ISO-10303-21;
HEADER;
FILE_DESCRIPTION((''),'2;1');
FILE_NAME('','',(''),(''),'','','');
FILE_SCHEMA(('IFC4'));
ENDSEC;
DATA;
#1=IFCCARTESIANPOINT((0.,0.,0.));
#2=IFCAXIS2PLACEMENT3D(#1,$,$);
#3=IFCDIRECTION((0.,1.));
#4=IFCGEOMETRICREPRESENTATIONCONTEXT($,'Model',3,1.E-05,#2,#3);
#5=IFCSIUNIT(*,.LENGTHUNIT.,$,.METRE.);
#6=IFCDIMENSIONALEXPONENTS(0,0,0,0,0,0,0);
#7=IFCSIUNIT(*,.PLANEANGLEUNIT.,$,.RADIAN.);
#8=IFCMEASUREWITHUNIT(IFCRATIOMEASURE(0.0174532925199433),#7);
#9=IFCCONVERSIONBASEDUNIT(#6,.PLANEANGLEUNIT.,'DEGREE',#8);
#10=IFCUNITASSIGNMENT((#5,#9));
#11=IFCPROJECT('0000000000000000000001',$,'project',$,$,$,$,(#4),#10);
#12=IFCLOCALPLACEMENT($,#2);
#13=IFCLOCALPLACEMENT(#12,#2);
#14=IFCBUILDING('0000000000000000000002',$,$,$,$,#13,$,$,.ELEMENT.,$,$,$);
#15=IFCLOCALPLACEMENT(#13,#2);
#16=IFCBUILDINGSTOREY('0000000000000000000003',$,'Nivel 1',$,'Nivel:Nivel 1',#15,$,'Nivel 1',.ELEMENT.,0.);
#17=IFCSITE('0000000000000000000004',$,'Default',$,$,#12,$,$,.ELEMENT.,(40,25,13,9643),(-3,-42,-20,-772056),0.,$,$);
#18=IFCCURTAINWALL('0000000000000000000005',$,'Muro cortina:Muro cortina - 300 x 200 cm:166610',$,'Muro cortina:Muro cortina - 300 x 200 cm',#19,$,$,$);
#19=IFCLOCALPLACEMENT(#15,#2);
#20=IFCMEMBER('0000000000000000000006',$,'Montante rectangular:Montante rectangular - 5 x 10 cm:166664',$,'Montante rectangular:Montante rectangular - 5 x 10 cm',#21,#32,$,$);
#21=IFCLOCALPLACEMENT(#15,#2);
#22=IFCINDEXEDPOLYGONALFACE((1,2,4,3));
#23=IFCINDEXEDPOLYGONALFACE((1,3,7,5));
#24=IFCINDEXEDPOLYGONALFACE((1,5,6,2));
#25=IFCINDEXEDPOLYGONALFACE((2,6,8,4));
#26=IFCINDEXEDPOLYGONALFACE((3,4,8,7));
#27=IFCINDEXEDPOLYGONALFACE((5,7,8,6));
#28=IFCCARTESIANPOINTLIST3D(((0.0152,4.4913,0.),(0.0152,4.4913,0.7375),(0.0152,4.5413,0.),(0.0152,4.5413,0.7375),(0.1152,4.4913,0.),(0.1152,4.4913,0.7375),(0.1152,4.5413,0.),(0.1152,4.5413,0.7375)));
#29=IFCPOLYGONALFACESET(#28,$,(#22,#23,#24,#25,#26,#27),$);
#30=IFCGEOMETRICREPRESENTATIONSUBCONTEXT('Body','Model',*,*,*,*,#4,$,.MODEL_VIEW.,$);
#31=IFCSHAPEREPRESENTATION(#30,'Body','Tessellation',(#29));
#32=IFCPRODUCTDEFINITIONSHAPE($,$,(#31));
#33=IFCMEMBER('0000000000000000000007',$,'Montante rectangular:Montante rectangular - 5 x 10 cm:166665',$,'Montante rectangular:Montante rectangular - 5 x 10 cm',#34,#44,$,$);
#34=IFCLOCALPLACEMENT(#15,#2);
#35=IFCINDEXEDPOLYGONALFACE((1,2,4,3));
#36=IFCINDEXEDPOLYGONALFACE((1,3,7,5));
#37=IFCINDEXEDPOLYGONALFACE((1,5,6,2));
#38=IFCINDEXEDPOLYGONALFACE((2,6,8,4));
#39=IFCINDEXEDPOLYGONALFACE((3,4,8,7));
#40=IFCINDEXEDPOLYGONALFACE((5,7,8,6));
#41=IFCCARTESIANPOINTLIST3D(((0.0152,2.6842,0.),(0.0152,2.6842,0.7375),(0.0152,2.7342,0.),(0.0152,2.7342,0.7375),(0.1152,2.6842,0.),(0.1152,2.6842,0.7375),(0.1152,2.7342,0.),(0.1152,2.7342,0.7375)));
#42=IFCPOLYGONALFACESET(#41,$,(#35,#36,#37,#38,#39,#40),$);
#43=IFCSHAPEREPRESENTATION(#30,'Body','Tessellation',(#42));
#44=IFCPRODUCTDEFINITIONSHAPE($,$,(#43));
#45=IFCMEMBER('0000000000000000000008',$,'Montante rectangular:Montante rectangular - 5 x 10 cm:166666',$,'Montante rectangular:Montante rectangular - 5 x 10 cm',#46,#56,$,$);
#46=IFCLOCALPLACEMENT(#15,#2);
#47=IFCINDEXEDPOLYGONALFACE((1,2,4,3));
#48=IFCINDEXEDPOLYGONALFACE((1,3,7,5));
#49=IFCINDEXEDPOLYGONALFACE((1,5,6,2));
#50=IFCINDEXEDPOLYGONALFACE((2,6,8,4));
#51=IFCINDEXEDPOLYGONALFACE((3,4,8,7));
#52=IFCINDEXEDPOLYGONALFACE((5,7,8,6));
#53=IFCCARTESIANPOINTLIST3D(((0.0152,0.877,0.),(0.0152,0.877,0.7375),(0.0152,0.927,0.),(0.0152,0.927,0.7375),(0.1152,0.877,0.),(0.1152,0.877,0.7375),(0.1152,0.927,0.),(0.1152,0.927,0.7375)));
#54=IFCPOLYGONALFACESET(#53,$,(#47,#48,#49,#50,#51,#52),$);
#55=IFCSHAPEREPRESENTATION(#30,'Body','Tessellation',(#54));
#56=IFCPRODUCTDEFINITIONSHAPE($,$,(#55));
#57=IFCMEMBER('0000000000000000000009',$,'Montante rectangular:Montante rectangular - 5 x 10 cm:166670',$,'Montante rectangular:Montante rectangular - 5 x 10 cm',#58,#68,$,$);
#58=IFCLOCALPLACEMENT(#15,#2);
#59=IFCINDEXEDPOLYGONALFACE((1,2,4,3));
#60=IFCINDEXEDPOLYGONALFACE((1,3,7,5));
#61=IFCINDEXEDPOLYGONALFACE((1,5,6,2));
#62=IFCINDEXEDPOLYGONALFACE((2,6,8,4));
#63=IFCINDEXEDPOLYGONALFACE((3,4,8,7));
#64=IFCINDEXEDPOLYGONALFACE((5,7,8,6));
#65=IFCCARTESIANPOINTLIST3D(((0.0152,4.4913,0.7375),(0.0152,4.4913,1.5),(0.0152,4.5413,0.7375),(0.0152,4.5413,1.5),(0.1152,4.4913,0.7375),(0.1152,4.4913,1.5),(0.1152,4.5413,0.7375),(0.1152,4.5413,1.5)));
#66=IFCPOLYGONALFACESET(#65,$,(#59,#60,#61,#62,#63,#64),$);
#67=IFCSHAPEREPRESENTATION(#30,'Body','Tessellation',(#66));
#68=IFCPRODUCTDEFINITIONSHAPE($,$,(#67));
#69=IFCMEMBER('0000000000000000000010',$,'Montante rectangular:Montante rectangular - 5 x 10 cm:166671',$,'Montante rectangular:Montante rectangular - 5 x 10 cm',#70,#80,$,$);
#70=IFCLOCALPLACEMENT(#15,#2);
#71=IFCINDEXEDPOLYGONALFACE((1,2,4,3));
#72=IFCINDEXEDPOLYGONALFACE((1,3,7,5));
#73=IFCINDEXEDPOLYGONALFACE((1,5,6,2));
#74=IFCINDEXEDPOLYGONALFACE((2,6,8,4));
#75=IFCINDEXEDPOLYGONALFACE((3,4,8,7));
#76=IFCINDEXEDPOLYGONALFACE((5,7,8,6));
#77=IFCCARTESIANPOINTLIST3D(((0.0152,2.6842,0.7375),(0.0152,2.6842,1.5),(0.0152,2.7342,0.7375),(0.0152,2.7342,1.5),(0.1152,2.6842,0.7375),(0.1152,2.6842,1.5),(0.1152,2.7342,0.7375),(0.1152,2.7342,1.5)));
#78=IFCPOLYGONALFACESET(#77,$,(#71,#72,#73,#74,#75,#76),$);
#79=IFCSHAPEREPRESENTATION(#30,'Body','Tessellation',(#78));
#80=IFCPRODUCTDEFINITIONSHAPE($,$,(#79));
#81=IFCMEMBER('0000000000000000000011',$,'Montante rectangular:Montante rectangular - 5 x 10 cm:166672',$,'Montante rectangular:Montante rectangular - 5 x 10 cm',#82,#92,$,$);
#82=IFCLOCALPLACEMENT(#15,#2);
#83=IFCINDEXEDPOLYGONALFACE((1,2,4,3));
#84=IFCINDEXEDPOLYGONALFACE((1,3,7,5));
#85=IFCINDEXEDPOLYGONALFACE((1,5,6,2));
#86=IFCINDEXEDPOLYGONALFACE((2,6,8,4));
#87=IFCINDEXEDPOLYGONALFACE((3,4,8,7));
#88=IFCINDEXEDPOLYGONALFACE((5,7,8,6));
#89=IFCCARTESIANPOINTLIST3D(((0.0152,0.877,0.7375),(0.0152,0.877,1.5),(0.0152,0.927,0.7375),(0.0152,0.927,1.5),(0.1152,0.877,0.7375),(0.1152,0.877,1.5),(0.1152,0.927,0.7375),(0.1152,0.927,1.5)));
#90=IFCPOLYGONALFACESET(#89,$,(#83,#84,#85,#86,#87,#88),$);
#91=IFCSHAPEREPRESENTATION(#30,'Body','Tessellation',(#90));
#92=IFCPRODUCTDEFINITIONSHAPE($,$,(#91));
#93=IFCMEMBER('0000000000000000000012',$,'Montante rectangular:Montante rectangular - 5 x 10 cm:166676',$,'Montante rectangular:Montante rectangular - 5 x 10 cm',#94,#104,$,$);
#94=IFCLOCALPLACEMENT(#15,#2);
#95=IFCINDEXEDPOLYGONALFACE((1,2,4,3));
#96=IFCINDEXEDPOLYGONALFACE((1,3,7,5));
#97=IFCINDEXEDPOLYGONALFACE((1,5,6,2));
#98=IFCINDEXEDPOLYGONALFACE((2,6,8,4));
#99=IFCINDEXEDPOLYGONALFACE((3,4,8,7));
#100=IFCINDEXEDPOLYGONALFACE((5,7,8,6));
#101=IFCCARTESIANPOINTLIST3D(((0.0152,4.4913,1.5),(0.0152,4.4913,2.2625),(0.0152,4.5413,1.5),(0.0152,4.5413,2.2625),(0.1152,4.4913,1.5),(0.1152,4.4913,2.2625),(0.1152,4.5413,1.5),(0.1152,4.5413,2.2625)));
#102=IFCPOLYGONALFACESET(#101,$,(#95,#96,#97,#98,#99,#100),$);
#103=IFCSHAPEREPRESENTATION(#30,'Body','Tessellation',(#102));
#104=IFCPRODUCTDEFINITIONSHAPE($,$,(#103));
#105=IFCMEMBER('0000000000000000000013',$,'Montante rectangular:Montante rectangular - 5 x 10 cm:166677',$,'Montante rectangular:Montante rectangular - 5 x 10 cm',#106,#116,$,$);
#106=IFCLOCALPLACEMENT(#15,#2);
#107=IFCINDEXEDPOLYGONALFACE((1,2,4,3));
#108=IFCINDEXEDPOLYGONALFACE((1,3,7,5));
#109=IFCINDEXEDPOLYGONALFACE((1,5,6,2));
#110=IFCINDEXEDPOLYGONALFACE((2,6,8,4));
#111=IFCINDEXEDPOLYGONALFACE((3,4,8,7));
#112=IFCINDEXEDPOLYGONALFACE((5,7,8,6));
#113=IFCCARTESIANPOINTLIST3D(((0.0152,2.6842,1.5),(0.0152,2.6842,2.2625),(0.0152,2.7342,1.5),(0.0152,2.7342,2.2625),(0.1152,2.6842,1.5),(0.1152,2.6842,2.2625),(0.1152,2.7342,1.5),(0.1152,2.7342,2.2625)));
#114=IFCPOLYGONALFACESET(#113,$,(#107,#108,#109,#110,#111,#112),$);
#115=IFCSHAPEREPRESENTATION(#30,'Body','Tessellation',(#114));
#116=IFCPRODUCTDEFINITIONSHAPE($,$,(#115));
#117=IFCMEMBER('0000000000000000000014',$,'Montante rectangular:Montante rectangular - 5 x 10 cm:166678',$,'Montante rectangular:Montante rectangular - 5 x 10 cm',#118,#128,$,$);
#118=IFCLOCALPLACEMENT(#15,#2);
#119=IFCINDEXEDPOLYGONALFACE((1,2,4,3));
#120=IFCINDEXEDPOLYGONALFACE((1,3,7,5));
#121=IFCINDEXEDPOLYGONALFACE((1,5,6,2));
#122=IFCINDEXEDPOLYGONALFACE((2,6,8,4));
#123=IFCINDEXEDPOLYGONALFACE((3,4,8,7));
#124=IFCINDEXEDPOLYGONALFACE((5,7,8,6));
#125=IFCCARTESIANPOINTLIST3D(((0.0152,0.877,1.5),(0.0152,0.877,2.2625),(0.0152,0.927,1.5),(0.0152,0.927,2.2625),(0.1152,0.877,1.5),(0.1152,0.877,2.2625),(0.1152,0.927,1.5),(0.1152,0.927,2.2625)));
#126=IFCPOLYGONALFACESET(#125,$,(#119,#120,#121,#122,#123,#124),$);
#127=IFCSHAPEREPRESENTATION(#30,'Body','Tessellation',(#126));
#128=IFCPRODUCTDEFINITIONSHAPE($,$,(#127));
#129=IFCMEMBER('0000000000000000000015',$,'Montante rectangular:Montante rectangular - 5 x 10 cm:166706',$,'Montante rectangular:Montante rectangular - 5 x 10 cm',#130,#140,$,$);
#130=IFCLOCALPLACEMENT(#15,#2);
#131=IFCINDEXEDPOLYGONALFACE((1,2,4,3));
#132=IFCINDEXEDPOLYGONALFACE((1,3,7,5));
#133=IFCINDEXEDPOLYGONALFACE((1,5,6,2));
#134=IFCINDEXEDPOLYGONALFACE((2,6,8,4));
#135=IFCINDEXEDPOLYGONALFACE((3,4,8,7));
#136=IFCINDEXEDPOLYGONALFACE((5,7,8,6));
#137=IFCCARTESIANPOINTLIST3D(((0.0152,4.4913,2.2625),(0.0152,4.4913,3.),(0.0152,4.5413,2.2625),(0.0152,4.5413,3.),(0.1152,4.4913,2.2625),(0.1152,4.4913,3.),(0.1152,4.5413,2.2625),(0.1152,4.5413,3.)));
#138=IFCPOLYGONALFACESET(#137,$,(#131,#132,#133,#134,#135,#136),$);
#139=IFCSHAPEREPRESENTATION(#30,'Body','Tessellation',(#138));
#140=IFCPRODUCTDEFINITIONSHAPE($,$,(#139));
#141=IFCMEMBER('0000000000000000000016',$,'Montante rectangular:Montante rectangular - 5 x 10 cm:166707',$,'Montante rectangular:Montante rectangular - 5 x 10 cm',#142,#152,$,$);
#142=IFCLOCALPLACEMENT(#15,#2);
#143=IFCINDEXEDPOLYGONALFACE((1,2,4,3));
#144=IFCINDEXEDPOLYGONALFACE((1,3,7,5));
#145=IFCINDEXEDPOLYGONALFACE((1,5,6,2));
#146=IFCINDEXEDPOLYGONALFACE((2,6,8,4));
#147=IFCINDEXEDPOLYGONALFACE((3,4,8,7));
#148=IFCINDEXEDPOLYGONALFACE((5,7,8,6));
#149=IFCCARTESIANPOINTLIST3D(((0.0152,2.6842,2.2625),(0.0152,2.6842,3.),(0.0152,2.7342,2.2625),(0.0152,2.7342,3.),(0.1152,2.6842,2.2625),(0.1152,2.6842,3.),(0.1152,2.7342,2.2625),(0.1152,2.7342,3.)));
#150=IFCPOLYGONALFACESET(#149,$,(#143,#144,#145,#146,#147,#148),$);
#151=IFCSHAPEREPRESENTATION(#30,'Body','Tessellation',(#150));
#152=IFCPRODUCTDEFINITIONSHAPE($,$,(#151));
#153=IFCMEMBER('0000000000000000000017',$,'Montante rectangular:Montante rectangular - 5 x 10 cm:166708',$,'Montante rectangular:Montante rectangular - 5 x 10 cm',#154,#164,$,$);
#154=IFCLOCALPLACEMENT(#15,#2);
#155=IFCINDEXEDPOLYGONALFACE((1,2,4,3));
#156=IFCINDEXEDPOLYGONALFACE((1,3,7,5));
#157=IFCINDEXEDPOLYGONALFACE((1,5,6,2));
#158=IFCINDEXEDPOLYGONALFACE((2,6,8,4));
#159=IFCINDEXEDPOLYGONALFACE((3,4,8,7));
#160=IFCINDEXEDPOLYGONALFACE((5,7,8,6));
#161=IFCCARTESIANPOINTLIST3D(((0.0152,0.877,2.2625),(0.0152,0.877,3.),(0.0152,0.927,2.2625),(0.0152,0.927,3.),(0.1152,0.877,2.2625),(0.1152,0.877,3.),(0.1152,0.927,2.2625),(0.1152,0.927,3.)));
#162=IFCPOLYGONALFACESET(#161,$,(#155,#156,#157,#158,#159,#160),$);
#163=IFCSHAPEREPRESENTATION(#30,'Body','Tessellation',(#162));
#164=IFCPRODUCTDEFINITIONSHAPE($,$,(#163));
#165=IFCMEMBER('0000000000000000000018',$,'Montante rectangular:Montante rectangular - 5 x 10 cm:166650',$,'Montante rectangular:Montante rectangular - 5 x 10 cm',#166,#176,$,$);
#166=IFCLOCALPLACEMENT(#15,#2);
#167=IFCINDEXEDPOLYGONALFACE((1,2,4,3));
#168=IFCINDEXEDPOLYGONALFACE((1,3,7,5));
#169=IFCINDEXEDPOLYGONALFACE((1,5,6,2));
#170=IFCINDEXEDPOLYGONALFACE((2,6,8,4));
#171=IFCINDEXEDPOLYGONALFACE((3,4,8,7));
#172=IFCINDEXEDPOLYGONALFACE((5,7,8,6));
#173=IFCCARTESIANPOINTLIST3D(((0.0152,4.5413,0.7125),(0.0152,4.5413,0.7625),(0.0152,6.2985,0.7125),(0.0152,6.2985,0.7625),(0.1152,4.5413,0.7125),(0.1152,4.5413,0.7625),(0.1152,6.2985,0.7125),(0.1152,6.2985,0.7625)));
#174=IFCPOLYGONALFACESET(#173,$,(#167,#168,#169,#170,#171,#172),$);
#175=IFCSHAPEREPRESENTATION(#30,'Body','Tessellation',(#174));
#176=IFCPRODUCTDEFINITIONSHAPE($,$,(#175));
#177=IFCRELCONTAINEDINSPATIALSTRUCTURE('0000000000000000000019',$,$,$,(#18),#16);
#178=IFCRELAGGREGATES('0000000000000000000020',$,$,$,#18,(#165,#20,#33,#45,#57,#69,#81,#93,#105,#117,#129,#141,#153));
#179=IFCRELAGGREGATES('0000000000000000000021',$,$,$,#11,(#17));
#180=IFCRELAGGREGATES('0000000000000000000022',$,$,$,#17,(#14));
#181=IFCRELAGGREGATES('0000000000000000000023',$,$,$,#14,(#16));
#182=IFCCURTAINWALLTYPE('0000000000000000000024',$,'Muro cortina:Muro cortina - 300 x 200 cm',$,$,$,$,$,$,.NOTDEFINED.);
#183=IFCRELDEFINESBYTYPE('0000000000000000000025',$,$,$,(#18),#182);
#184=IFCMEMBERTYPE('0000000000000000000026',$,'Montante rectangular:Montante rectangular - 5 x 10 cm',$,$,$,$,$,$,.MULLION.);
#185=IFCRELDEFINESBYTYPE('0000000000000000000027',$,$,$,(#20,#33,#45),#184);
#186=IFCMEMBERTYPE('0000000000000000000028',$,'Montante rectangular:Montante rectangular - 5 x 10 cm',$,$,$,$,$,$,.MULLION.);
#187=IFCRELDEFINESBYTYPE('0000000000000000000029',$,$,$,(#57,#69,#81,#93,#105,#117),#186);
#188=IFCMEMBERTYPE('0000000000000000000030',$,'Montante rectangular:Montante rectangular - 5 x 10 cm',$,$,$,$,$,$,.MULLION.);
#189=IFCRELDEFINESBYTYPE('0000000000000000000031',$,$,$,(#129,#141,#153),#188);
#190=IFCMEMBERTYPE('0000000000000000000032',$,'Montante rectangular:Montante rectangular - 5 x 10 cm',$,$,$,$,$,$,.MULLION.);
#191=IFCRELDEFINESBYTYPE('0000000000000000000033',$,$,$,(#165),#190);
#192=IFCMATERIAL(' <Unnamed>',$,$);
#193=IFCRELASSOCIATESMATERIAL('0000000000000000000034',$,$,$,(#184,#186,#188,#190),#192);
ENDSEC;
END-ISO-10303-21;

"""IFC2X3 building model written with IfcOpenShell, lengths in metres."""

from ifc_helpers import new_model, entity, si_unit, converted_unit, direction, frame, origin, origin_2d_with_axis, place, context, subcontext, project, spatial, rectangle, extrude, source, transform, mapped, material, type_object, type_shapes, element, aggregate, save


model = new_model("IFC2X3")

# Units and contexts
model_context = context("Model", 3, precision=1e-05, world=origin(), true_north=direction((0.0, 1.0)))
body_context = subcontext(model_context, "Body", "Model", "MODEL_VIEW")
ifc_project = project(units=[si_unit("LENGTHUNIT", "METRE"), converted_unit("PLANEANGLEUNIT", "DEGREE", entity("IfcRatioMeasure", 0.0174532925199433), si_unit("PLANEANGLEUNIT", "RADIAN"), dimensions=[0, 0, 0, 0, 0, 0, 0])], contexts=[model_context])

# Site, building, storey
site_placement = place(None, origin())
site = spatial("IfcSite", under=ifc_project, at=site_placement, Name="Default", CompositionType="ELEMENT", RefLatitude=(40, 25, 13, 9643), RefLongitude=(-3, -42, -20, -772056), RefElevation=0.0)
building_placement = place(site_placement, origin())
building = spatial("IfcBuilding", under=site, at=building_placement, CompositionType="ELEMENT")
storey_placement = place(building_placement, origin())
storey = spatial("IfcBuildingStorey", under=building, at=storey_placement, Name="Nivel 1", ObjectType="Nivel:Nivel 1", LongName="Nivel 1", CompositionType="ELEMENT", Elevation=0.0)

# Curtain wall, members
curtain_wall_type = type_object("IfcCurtainWallType", Name="Muro cortina:Muro cortina - 300 x 200 cm", PredefinedType="NOTDEFINED")
curtain_wall_placement = place(storey_placement, origin())
curtain_wall = element("IfcCurtainWall", 1, at=curtain_wall_placement, inside=storey, type_object=curtain_wall_type, Name="Muro cortina:Muro cortina - 300 x 200 cm:166610", ObjectType="Muro cortina:Muro cortina - 300 x 200 cm")
ifc_material_1 = material(Name=" <Unnamed>")
member_type_1 = type_object("IfcMemberType", Name="Montante rectangular:Montante rectangular - 5 x 10 cm", PredefinedType="MULLION", material=ifc_material_1)
shared_shape_1 = source(origin(), body_context, "Body", "SweptSolid", [
    extrude(rectangle(XDim=0.1, YDim=0.05, at=origin_2d_with_axis()), frame((0.0, 0.0, -0.7375), z_axis=(0.0, 0.0, 1.0), x_axis=(0.0, -1.0, 0.0)), (0.0, 0.0, 1.0), 0.7375),
])
type_shapes(member_type_1, [shared_shape_1])
member_1_placement = place(storey_placement, frame((0.0652, 4.5163, 0.0), z_axis=(0.0, 0.0, -1.0), x_axis=(0.0, -1.0, 0.0)))
member_1 = element("IfcMember", 2, at=member_1_placement, type_object=member_type_1, Name="Montante rectangular:Montante rectangular - 5 x 10 cm:166664", ObjectType="Montante rectangular:Montante rectangular - 5 x 10 cm", context=body_context, shape_type="MappedRepresentation", body=[
    mapped(shared_shape_1, transform((0.0, 0.0, 0.0), scale=1.0)),
])
member_2_placement = place(storey_placement, frame((0.0652, 2.7092, 0.0), z_axis=(0.0, 0.0, -1.0), x_axis=(0.0, -1.0, 0.0)))
member_2 = element("IfcMember", 3, at=member_2_placement, type_object=member_type_1, Name="Montante rectangular:Montante rectangular - 5 x 10 cm:166665", ObjectType="Montante rectangular:Montante rectangular - 5 x 10 cm", context=body_context, shape_type="MappedRepresentation", body=[
    mapped(shared_shape_1, transform((0.0, 0.0, 0.0), scale=1.0)),
])
member_3_placement = place(storey_placement, frame((0.0652, 0.902, 0.0), z_axis=(0.0, 0.0, -1.0), x_axis=(0.0, -1.0, 0.0)))
member_3 = element("IfcMember", 4, at=member_3_placement, type_object=member_type_1, Name="Montante rectangular:Montante rectangular - 5 x 10 cm:166666", ObjectType="Montante rectangular:Montante rectangular - 5 x 10 cm", context=body_context, shape_type="MappedRepresentation", body=[
    mapped(shared_shape_1, transform((0.0, 0.0, 0.0), scale=1.0)),
])
member_type_2 = type_object("IfcMemberType", Name="Montante rectangular:Montante rectangular - 5 x 10 cm", PredefinedType="MULLION", material=ifc_material_1)
shared_shape_2 = source(origin(), body_context, "Body", "SweptSolid", [
    extrude(rectangle(XDim=0.1, YDim=0.05, at=origin_2d_with_axis()), frame((0.0, 0.0, -0.7625), z_axis=(0.0, 0.0, 1.0), x_axis=(0.0, -1.0, 0.0)), (0.0, 0.0, 1.0), 0.7625),
])
type_shapes(member_type_2, [shared_shape_2])
member_4_placement = place(storey_placement, frame((0.0652, 4.5163, 0.7375), z_axis=(0.0, 0.0, -1.0), x_axis=(0.0, -1.0, 0.0)))
member_4 = element("IfcMember", 5, at=member_4_placement, type_object=member_type_2, Name="Montante rectangular:Montante rectangular - 5 x 10 cm:166670", ObjectType="Montante rectangular:Montante rectangular - 5 x 10 cm", context=body_context, shape_type="MappedRepresentation", body=[
    mapped(shared_shape_2, transform((0.0, 0.0, 0.0), scale=1.0)),
])
member_5_placement = place(storey_placement, frame((0.0652, 2.7092, 0.7375), z_axis=(0.0, 0.0, -1.0), x_axis=(0.0, -1.0, 0.0)))
member_5 = element("IfcMember", 6, at=member_5_placement, type_object=member_type_2, Name="Montante rectangular:Montante rectangular - 5 x 10 cm:166671", ObjectType="Montante rectangular:Montante rectangular - 5 x 10 cm", context=body_context, shape_type="MappedRepresentation", body=[
    mapped(shared_shape_2, transform((0.0, 0.0, 0.0), scale=1.0)),
])
member_6_placement = place(storey_placement, frame((0.0652, 0.902, 0.7375), z_axis=(0.0, 0.0, -1.0), x_axis=(0.0, -1.0, 0.0)))
member_6 = element("IfcMember", 7, at=member_6_placement, type_object=member_type_2, Name="Montante rectangular:Montante rectangular - 5 x 10 cm:166672", ObjectType="Montante rectangular:Montante rectangular - 5 x 10 cm", context=body_context, shape_type="MappedRepresentation", body=[
    mapped(shared_shape_2, transform((0.0, 0.0, 0.0), scale=1.0)),
])
member_7_placement = place(storey_placement, frame((0.0652, 4.5163, 1.5), z_axis=(0.0, 0.0, -1.0), x_axis=(0.0, -1.0, 0.0)))
member_7 = element("IfcMember", 8, at=member_7_placement, type_object=member_type_2, Name="Montante rectangular:Montante rectangular - 5 x 10 cm:166676", ObjectType="Montante rectangular:Montante rectangular - 5 x 10 cm", context=body_context, shape_type="MappedRepresentation", body=[
    mapped(shared_shape_2, transform((0.0, 0.0, 0.0), scale=1.0)),
])
member_8_placement = place(storey_placement, frame((0.0652, 2.7092, 1.5), z_axis=(0.0, 0.0, -1.0), x_axis=(0.0, -1.0, 0.0)))
member_8 = element("IfcMember", 9, at=member_8_placement, type_object=member_type_2, Name="Montante rectangular:Montante rectangular - 5 x 10 cm:166677", ObjectType="Montante rectangular:Montante rectangular - 5 x 10 cm", context=body_context, shape_type="MappedRepresentation", body=[
    mapped(shared_shape_2, transform((0.0, 0.0, 0.0), scale=1.0)),
])
member_9_placement = place(storey_placement, frame((0.0652, 0.902, 1.5), z_axis=(0.0, 0.0, -1.0), x_axis=(0.0, -1.0, 0.0)))
member_9 = element("IfcMember", 10, at=member_9_placement, type_object=member_type_2, Name="Montante rectangular:Montante rectangular - 5 x 10 cm:166678", ObjectType="Montante rectangular:Montante rectangular - 5 x 10 cm", context=body_context, shape_type="MappedRepresentation", body=[
    mapped(shared_shape_2, transform((0.0, 0.0, 0.0), scale=1.0)),
])
member_type_3 = type_object("IfcMemberType", Name="Montante rectangular:Montante rectangular - 5 x 10 cm", PredefinedType="MULLION", material=ifc_material_1)
shared_shape_3 = source(origin(), body_context, "Body", "SweptSolid", [
    extrude(rectangle(XDim=0.1, YDim=0.05, at=origin_2d_with_axis()), frame((0.0, 0.0, -0.7375), z_axis=(0.0, 0.0, 1.0), x_axis=(0.0, -1.0, 0.0)), (0.0, 0.0, 1.0), 0.7375),
])
type_shapes(member_type_3, [shared_shape_3])
member_10_placement = place(storey_placement, frame((0.0652, 4.5163, 2.2625), z_axis=(0.0, 0.0, -1.0), x_axis=(0.0, -1.0, 0.0)))
member_10 = element("IfcMember", 11, at=member_10_placement, type_object=member_type_3, Name="Montante rectangular:Montante rectangular - 5 x 10 cm:166706", ObjectType="Montante rectangular:Montante rectangular - 5 x 10 cm", context=body_context, shape_type="MappedRepresentation", body=[
    mapped(shared_shape_3, transform((0.0, 0.0, 0.0), scale=1.0)),
])
member_11_placement = place(storey_placement, frame((0.0652, 2.7092, 2.2625), z_axis=(0.0, 0.0, -1.0), x_axis=(0.0, -1.0, 0.0)))
member_11 = element("IfcMember", 12, at=member_11_placement, type_object=member_type_3, Name="Montante rectangular:Montante rectangular - 5 x 10 cm:166707", ObjectType="Montante rectangular:Montante rectangular - 5 x 10 cm", context=body_context, shape_type="MappedRepresentation", body=[
    mapped(shared_shape_3, transform((0.0, 0.0, 0.0), scale=1.0)),
])
member_12_placement = place(storey_placement, frame((0.0652, 0.902, 2.2625), z_axis=(0.0, 0.0, -1.0), x_axis=(0.0, -1.0, 0.0)))
member_12 = element("IfcMember", 13, at=member_12_placement, type_object=member_type_3, Name="Montante rectangular:Montante rectangular - 5 x 10 cm:166708", ObjectType="Montante rectangular:Montante rectangular - 5 x 10 cm", context=body_context, shape_type="MappedRepresentation", body=[
    mapped(shared_shape_3, transform((0.0, 0.0, 0.0), scale=1.0)),
])
member_type_4 = type_object("IfcMemberType", Name="Montante rectangular:Montante rectangular - 5 x 10 cm", PredefinedType="MULLION", material=ifc_material_1)
shared_shape_4 = source(origin(), body_context, "Body", "SweptSolid", [
    extrude(rectangle(XDim=0.1, YDim=0.05, at=origin_2d_with_axis()), frame((0.0, 0.0, -1.7571), z_axis=(0.0, 0.0, 1.0), x_axis=(0.0, -1.0, 0.0)), (0.0, 0.0, 1.0), 1.7571),
])
type_shapes(member_type_4, [shared_shape_4])
member_13_placement = place(storey_placement, frame((0.0652, 4.5413, 0.7375), z_axis=(0.0, -1.0, 0.0), x_axis=(0.0, 0.0, 1.0)))
member_13 = element("IfcMember", 14, at=member_13_placement, type_object=member_type_4, Name="Montante rectangular:Montante rectangular - 5 x 10 cm:166650", ObjectType="Montante rectangular:Montante rectangular - 5 x 10 cm", context=body_context, shape_type="MappedRepresentation", body=[
    mapped(shared_shape_4, transform((0.0, 0.0, 0.0), scale=1.0)),
])
aggregate(curtain_wall, [member_13, member_1, member_2, member_3, member_4, member_5, member_6, member_7, member_8, member_9, member_10, member_11, member_12])

save(model, "model.ifc")
